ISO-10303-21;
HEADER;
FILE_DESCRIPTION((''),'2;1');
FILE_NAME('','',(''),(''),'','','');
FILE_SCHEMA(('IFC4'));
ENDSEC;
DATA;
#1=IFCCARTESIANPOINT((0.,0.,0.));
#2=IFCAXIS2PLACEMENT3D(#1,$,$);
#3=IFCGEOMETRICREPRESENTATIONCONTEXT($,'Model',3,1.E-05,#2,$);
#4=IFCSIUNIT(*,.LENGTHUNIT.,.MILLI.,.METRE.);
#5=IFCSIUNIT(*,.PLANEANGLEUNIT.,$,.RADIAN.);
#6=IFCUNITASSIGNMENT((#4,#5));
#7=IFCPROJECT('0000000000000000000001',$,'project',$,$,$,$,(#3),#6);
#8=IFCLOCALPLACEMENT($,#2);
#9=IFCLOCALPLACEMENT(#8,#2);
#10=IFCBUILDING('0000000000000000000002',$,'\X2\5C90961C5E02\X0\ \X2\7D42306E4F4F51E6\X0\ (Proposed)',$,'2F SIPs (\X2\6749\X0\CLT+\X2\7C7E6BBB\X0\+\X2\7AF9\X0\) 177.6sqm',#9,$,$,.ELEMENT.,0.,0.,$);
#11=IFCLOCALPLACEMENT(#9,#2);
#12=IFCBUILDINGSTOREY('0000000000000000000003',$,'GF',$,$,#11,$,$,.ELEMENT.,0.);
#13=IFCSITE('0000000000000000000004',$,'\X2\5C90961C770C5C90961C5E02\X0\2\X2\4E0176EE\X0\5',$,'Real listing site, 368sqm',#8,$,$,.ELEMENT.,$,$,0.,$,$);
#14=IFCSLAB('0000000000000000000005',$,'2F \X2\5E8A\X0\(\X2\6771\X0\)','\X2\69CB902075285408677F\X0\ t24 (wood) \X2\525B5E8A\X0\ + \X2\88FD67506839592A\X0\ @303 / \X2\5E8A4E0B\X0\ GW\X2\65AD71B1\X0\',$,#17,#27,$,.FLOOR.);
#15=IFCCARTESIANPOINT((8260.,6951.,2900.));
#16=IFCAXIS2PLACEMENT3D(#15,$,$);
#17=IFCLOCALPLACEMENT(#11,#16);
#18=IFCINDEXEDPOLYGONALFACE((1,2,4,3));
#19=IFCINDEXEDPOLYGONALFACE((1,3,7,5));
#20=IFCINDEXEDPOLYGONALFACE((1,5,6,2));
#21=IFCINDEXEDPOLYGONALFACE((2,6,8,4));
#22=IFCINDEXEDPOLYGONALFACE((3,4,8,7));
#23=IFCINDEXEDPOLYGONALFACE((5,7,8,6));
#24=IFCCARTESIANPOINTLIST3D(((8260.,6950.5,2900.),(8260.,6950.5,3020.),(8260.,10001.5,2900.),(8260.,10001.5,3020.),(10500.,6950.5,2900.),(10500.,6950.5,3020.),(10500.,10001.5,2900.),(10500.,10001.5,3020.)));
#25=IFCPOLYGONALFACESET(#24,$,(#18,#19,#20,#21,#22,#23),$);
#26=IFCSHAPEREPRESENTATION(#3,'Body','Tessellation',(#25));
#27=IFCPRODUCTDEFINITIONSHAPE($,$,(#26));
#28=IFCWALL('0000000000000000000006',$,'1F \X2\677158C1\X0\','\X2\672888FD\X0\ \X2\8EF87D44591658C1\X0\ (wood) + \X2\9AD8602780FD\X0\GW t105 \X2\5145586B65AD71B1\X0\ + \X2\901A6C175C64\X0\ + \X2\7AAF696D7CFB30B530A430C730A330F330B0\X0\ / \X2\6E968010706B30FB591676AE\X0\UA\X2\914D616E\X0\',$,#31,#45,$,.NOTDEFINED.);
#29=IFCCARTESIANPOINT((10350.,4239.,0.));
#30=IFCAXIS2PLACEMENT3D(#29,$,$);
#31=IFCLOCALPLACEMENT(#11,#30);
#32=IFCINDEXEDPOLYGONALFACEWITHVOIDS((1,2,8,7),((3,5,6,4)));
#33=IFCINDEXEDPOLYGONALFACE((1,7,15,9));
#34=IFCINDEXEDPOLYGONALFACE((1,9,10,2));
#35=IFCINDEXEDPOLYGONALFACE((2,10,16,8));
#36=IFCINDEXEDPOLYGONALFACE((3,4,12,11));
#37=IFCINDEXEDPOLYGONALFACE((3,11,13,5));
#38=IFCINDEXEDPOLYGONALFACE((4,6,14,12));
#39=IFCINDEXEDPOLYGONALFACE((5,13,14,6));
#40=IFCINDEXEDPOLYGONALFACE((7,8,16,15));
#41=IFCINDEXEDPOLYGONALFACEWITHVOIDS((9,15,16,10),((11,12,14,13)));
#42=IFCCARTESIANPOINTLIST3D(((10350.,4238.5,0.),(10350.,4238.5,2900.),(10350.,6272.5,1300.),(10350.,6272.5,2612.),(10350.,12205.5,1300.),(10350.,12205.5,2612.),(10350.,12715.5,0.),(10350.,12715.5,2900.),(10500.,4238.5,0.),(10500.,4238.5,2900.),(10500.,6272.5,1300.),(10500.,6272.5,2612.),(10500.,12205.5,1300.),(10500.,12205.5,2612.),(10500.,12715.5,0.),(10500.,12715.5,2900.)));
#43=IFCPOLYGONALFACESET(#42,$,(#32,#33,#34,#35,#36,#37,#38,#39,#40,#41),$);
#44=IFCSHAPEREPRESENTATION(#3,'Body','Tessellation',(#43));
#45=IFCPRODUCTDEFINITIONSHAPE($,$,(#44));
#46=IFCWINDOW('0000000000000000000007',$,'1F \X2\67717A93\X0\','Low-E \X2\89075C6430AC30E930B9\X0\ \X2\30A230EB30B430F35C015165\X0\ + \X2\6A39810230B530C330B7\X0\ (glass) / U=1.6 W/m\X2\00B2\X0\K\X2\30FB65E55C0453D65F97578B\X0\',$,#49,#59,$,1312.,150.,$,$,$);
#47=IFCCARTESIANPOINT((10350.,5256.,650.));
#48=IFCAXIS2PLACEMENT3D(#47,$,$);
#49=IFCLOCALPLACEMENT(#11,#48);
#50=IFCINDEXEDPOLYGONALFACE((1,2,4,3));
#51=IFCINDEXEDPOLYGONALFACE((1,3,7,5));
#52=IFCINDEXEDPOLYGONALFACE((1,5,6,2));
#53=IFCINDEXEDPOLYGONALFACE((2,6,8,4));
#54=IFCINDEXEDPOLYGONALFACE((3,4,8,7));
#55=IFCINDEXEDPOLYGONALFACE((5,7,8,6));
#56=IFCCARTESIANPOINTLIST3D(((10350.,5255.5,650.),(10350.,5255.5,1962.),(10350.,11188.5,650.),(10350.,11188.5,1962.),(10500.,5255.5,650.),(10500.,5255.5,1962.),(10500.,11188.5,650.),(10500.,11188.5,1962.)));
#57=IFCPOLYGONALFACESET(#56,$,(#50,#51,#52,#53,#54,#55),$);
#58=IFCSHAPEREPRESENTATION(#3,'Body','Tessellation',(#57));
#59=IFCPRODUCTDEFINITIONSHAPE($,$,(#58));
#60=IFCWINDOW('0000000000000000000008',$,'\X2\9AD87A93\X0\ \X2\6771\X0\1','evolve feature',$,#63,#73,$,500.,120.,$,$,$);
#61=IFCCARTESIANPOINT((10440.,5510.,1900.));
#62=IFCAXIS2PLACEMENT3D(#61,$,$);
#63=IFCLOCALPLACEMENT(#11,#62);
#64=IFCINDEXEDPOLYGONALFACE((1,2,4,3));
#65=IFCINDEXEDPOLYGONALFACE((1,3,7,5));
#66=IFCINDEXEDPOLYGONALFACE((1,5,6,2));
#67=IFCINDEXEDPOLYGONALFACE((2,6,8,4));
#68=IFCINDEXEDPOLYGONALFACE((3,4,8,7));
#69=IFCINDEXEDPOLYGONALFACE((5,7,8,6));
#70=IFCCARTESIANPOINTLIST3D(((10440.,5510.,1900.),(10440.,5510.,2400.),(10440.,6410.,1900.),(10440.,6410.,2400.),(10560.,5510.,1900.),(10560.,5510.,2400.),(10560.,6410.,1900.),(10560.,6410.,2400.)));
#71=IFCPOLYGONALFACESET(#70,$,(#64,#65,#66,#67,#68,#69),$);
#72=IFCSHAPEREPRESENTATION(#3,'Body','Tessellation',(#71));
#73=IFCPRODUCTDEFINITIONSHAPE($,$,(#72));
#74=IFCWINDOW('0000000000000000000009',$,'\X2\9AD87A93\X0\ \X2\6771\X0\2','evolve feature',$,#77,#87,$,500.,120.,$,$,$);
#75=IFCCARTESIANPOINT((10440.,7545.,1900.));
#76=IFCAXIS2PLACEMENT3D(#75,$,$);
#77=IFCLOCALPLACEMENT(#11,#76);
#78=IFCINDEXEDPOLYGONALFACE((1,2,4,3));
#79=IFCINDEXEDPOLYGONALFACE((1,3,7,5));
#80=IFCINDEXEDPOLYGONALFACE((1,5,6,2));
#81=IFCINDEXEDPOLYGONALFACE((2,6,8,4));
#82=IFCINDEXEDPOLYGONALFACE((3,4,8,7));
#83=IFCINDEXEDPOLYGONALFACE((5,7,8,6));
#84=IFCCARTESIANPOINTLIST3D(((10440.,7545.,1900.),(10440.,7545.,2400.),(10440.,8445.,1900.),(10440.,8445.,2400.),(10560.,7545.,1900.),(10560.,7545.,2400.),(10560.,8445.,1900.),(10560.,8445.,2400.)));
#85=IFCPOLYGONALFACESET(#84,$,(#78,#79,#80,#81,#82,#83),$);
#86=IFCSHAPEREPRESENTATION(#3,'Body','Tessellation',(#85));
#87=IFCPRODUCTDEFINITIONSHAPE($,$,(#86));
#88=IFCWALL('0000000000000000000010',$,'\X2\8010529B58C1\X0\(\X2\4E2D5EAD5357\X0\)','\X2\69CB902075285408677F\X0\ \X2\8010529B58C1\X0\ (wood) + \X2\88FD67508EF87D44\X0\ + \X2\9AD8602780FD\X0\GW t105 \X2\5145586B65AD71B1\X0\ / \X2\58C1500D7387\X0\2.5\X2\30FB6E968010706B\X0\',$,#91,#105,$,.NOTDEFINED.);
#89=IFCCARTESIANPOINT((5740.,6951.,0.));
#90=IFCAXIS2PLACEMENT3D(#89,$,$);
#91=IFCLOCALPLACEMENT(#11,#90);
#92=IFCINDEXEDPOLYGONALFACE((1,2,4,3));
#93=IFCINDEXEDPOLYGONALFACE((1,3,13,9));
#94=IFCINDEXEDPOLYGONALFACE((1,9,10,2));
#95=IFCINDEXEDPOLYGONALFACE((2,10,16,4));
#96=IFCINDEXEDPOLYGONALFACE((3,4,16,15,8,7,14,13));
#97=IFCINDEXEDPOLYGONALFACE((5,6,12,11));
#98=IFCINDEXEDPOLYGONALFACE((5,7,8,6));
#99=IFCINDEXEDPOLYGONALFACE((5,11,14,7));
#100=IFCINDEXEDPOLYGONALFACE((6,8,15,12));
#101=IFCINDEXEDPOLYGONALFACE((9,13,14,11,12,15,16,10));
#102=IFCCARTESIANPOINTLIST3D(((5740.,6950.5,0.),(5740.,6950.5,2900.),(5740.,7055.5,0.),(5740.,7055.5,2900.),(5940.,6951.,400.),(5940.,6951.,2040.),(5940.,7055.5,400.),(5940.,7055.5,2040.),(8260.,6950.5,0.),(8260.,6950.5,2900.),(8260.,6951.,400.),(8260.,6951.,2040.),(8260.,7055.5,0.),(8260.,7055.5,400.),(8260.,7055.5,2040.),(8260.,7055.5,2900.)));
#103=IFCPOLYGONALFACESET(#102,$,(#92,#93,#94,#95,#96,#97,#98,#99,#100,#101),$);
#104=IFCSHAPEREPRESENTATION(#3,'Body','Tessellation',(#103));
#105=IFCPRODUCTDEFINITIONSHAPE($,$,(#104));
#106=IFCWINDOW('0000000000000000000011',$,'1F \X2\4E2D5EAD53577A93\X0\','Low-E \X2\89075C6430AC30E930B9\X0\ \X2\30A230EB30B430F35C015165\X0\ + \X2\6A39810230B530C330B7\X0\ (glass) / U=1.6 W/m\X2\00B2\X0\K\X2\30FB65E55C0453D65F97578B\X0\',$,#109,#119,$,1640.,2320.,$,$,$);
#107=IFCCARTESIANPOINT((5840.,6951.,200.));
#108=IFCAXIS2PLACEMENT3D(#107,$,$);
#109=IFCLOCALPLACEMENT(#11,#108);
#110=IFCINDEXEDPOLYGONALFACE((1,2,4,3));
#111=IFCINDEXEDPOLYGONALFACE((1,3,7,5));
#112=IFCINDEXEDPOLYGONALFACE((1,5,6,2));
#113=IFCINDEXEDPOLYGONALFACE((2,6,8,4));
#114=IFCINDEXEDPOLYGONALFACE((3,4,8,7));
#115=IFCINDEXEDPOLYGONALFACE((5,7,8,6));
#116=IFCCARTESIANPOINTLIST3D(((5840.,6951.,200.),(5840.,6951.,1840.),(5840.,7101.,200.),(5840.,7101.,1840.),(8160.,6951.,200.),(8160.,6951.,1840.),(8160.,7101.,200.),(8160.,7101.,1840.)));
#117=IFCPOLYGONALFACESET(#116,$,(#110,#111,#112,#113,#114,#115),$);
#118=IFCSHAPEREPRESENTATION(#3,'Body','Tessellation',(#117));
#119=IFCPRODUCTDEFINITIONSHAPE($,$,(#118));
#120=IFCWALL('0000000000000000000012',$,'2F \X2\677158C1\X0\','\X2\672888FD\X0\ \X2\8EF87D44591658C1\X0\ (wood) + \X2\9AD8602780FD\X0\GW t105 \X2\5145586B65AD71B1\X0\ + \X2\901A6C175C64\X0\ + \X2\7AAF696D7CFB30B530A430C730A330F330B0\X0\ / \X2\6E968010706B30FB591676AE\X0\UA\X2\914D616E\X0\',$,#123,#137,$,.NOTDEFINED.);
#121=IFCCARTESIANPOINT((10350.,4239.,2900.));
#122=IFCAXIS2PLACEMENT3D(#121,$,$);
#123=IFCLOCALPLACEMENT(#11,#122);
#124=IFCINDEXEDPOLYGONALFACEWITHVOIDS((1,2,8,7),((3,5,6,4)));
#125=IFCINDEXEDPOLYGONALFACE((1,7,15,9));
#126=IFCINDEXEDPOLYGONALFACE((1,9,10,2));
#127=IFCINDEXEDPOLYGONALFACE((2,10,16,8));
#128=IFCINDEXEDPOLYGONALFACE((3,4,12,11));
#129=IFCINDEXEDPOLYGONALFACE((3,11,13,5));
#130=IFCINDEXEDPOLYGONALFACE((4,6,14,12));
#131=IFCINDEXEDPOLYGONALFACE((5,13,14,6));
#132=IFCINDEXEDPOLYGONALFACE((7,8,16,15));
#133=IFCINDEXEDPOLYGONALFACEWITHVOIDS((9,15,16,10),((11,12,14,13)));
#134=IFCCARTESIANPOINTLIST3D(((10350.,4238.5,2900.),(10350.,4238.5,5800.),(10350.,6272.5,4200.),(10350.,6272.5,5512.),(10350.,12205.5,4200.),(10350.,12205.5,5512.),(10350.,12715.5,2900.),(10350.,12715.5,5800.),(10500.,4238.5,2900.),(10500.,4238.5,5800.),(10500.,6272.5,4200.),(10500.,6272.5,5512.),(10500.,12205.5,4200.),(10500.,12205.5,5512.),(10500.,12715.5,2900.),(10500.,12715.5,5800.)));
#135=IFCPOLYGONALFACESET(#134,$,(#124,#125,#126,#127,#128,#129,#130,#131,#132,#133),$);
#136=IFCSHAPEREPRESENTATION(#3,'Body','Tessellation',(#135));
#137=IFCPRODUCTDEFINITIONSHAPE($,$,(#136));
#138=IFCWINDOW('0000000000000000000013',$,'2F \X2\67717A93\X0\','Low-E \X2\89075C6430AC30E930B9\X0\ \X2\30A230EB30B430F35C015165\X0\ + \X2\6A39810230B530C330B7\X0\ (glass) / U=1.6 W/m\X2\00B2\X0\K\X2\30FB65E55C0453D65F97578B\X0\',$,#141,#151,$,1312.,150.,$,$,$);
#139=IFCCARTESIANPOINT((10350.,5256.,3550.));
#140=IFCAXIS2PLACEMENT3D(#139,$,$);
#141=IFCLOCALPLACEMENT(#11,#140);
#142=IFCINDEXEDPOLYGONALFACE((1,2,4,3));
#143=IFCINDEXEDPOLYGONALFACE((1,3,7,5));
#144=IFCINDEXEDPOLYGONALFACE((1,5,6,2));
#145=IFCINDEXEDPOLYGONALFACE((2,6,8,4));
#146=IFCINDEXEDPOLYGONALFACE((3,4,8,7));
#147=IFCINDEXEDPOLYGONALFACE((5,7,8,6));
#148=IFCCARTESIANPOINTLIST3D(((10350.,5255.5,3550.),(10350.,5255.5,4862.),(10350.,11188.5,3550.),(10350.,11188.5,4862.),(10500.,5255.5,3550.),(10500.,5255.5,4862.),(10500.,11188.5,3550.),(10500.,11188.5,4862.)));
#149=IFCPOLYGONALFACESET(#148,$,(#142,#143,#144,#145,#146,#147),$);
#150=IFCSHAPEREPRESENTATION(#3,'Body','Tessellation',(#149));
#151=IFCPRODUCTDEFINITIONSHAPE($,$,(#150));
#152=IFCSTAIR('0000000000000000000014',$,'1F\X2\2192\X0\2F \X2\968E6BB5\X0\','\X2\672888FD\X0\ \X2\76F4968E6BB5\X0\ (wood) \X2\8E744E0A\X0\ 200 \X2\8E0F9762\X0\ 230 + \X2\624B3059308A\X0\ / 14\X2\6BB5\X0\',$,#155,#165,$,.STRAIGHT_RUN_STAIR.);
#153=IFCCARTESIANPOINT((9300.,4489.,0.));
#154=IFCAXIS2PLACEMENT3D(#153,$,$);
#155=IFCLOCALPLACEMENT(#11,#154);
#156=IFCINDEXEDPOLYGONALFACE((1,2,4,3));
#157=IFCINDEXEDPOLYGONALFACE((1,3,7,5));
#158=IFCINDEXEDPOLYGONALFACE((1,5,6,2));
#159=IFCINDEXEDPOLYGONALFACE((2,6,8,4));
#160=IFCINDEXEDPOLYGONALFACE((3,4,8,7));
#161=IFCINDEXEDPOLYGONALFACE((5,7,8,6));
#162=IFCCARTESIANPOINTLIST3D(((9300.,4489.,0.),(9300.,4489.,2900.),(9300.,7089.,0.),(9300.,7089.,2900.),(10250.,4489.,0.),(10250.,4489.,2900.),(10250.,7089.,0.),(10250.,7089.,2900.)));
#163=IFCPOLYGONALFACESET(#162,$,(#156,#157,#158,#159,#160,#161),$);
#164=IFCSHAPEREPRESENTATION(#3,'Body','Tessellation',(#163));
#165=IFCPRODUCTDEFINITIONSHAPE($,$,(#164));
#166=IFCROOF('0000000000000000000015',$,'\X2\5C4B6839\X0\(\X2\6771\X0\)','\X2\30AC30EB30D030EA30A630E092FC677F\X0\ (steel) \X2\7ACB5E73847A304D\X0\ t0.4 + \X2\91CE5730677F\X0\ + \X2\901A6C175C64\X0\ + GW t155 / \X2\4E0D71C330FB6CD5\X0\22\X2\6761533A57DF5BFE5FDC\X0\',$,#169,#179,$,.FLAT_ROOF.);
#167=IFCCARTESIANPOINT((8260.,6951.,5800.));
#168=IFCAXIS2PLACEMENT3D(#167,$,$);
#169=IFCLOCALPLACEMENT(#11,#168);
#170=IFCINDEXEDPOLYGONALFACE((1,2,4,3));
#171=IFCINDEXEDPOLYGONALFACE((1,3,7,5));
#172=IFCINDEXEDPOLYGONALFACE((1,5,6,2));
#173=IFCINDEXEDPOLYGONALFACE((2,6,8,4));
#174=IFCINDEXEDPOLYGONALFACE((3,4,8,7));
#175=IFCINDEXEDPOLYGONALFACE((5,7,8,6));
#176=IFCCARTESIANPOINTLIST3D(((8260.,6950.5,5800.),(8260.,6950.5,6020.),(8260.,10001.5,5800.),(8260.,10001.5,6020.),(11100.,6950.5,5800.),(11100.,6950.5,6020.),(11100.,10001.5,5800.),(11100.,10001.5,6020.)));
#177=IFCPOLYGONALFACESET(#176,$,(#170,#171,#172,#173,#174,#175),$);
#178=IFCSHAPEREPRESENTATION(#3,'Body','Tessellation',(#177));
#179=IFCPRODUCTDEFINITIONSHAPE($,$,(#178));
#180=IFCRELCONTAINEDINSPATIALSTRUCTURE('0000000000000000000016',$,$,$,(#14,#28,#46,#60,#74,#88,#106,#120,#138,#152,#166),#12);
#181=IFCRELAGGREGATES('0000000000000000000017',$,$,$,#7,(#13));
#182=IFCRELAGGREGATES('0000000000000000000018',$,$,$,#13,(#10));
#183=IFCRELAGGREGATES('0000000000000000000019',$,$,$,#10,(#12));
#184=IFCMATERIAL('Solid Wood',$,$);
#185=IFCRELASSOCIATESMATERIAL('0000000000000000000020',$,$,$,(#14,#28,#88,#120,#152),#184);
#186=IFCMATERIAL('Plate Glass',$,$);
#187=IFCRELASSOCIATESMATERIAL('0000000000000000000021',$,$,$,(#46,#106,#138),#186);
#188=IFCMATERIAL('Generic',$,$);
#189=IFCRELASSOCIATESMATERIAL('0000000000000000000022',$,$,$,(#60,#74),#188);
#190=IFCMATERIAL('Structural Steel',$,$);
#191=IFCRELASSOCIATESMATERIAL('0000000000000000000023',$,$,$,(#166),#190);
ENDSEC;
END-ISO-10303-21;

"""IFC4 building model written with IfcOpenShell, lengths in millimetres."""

from ifc_helpers import new_model, si_unit, frame, frame_2d, origin, place, context, project, spatial, rectangle, extrude, material, element, fill, save


model = new_model("IFC4")

# Units and contexts
model_context = context("Model", 3, precision=1e-05, world=origin())
ifc_project = project(units=[si_unit("LENGTHUNIT", "METRE", prefix="MILLI"), si_unit("PLANEANGLEUNIT", "RADIAN")], contexts=[model_context])

# Site, building, storey
site_placement = place(None, origin())
site = spatial("IfcSite", under=ifc_project, at=site_placement, Name="岐阜県岐阜市2丁目5", ObjectType="Real listing site, 368sqm", CompositionType="ELEMENT", RefElevation=0.0)
building_placement = place(site_placement, origin())
building = spatial("IfcBuilding", under=site, at=building_placement, Name="岐阜市 終の住処 (Proposed)", ObjectType="2F SIPs (杉CLT+籾殻+竹) 177.6sqm", CompositionType="ELEMENT", ElevationOfRefHeight=0.0, ElevationOfTerrain=0.0)
storey_placement = place(building_placement, origin())
storey = spatial("IfcBuildingStorey", under=building, at=storey_placement, Name="GF", CompositionType="ELEMENT", Elevation=0.0)

# Slab
ifc_material_1 = material(Name="Solid Wood")
slab_1_placement = place(storey_placement, frame((8260.0, 6951.0, 2900.0)))
element("IfcSlab", 1, at=slab_1_placement, inside=storey, material=ifc_material_1, Name="2F 床(東)", Description="構造用合板 t24 (wood) 剛床 + 製材根太 @303 / 床下 GW断熱", PredefinedType="FLOOR", context=model_context, shape_type="SweptSolid", body=[
    extrude(rectangle(XDim=2240.0, YDim=3051.0, at=frame_2d((1120.0, 1525.0))), frame((8260.0, 6951.0, 2900.0)), (0.0, 0.0, 1.0), 120.0),
])

# Wall, openings, windows
wall_1_placement = place(storey_placement, frame((10350.0, 4239.0, 0.0)))
wall_1 = element("IfcWall", 2, at=wall_1_placement, inside=storey, material=ifc_material_1, Name="1F 東壁", Description="木製 軸組外壁 (wood) + 高性能GW t105 充填断熱 + 通気層 + 窯業系サイディング / 準耐火・外皮UA配慮", PredefinedType="NOTDEFINED", context=model_context, shape_type="SweptSolid", body=[
    extrude(rectangle(XDim=150.0, YDim=8477.0, at=frame_2d((75.0, 4238.0))), frame((10350.0, 4239.0, 0.0)), (0.0, 0.0, 1.0), 2900.0),
])
opening_1_placement = place(storey_placement, frame((10350.0, 5256.0, 650.0)))
opening_1 = element("IfcOpeningElement", 3, at=opening_1_placement, cuts=wall_1, PredefinedType="NOTDEFINED", context=model_context, shape_type="SweptSolid", body=[
    extrude(rectangle(XDim=150.0, YDim=5933.0, at=frame_2d((75.0, 2966.0))), frame((10350.0, 5256.0, 650.0)), (0.0, 0.0, 1.0), 1312.0),
])
opening_2_placement = place(storey_placement, frame((10440.0, 5510.0, 1900.0)))
opening_2 = element("IfcOpeningElement", 4, at=opening_2_placement, cuts=wall_1, PredefinedType="NOTDEFINED", context=model_context, shape_type="SweptSolid", body=[
    extrude(rectangle(XDim=120.0, YDim=900.0, at=frame_2d((60.0, 450.0))), frame((10440.0, 5510.0, 1900.0)), (0.0, 0.0, 1.0), 500.0),
])
opening_3_placement = place(storey_placement, frame((10440.0, 7545.0, 1900.0)))
opening_3 = element("IfcOpeningElement", 5, at=opening_3_placement, cuts=wall_1, PredefinedType="NOTDEFINED", context=model_context, shape_type="SweptSolid", body=[
    extrude(rectangle(XDim=120.0, YDim=900.0, at=frame_2d((60.0, 450.0))), frame((10440.0, 7545.0, 1900.0)), (0.0, 0.0, 1.0), 500.0),
])
ifc_material_2 = material(Name="Plate Glass")
window_1_placement = place(storey_placement, frame((10350.0, 5256.0, 650.0)))
window_1 = element("IfcWindow", 6, at=window_1_placement, inside=storey, material=ifc_material_2, Name="1F 東窓", Description="Low-E 複層ガラス アルゴン封入 + 樹脂サッシ (glass) / U=1.6 W/m²K・日射取得型", OverallHeight=1312.0, OverallWidth=150.0, context=model_context, shape_type="SweptSolid", body=[
    extrude(rectangle(XDim=150.0, YDim=5933.0, at=frame_2d((75.0, 2966.0))), frame((10350.0, 5256.0, 650.0)), (0.0, 0.0, 1.0), 1312.0),
])
fill(opening_1, window_1)
ifc_material_3 = material(Name="Generic")
window_2_placement = place(storey_placement, frame((10440.0, 5510.0, 1900.0)))
window_2 = element("IfcWindow", 7, at=window_2_placement, inside=storey, material=ifc_material_3, Name="高窓 東1", Description="evolve feature", OverallHeight=500.0, OverallWidth=120.0, context=model_context, shape_type="SweptSolid", body=[
    extrude(rectangle(XDim=120.0, YDim=900.0, at=frame_2d((60.0, 450.0))), frame((10440.0, 5510.0, 1900.0)), (0.0, 0.0, 1.0), 500.0),
])
fill(opening_2, window_2)
window_3_placement = place(storey_placement, frame((10440.0, 7545.0, 1900.0)))
window_3 = element("IfcWindow", 8, at=window_3_placement, inside=storey, material=ifc_material_3, Name="高窓 東2", Description="evolve feature", OverallHeight=500.0, OverallWidth=120.0, context=model_context, shape_type="SweptSolid", body=[
    extrude(rectangle(XDim=120.0, YDim=900.0, at=frame_2d((60.0, 450.0))), frame((10440.0, 7545.0, 1900.0)), (0.0, 0.0, 1.0), 500.0),
])
fill(opening_3, window_3)

# Wall, opening, window
wall_2_placement = place(storey_placement, frame((5740.0, 6951.0, 0.0)))
wall_2 = element("IfcWall", 9, at=wall_2_placement, inside=storey, material=ifc_material_1, Name="耐力壁(中庭南)", Description="構造用合板 耐力壁 (wood) + 製材軸組 + 高性能GW t105 充填断熱 / 壁倍率2.5・準耐火", PredefinedType="NOTDEFINED", context=model_context, shape_type="SweptSolid", body=[
    extrude(rectangle(XDim=2520.0, YDim=105.0, at=frame_2d((1260.0, 52.0))), frame((5740.0, 6951.0, 0.0)), (0.0, 0.0, 1.0), 2900.0),
])
opening_4_placement = place(storey_placement, frame((5840.0, 6951.0, 200.0)))
opening_4 = element("IfcOpeningElement", 10, at=opening_4_placement, cuts=wall_2, PredefinedType="NOTDEFINED", context=model_context, shape_type="SweptSolid", body=[
    extrude(rectangle(XDim=2320.0, YDim=150.0, at=frame_2d((1160.0, 75.0))), frame((5840.0, 6951.0, 200.0)), (0.0, 0.0, 1.0), 1640.0),
])
window_4_placement = place(storey_placement, frame((5840.0, 6951.0, 200.0)))
window_4 = element("IfcWindow", 11, at=window_4_placement, inside=storey, material=ifc_material_2, Name="1F 中庭南窓", Description="Low-E 複層ガラス アルゴン封入 + 樹脂サッシ (glass) / U=1.6 W/m²K・日射取得型", OverallHeight=1640.0, OverallWidth=2320.0, context=model_context, shape_type="SweptSolid", body=[
    extrude(rectangle(XDim=2320.0, YDim=150.0, at=frame_2d((1160.0, 75.0))), frame((5840.0, 6951.0, 200.0)), (0.0, 0.0, 1.0), 1640.0),
])
fill(opening_4, window_4)

# Wall, opening, window
wall_3_placement = place(storey_placement, frame((10350.0, 4239.0, 2900.0)))
wall_3 = element("IfcWall", 12, at=wall_3_placement, inside=storey, material=ifc_material_1, Name="2F 東壁", Description="木製 軸組外壁 (wood) + 高性能GW t105 充填断熱 + 通気層 + 窯業系サイディング / 準耐火・外皮UA配慮", PredefinedType="NOTDEFINED", context=model_context, shape_type="SweptSolid", body=[
    extrude(rectangle(XDim=150.0, YDim=8477.0, at=frame_2d((75.0, 4238.0))), frame((10350.0, 4239.0, 2900.0)), (0.0, 0.0, 1.0), 2900.0),
])
opening_5_placement = place(storey_placement, frame((10350.0, 5256.0, 3550.0)))
opening_5 = element("IfcOpeningElement", 13, at=opening_5_placement, cuts=wall_3, PredefinedType="NOTDEFINED", context=model_context, shape_type="SweptSolid", body=[
    extrude(rectangle(XDim=150.0, YDim=5933.0, at=frame_2d((75.0, 2966.0))), frame((10350.0, 5256.0, 3550.0)), (0.0, 0.0, 1.0), 1312.0),
])
window_5_placement = place(storey_placement, frame((10350.0, 5256.0, 3550.0)))
window_5 = element("IfcWindow", 14, at=window_5_placement, inside=storey, material=ifc_material_2, Name="2F 東窓", Description="Low-E 複層ガラス アルゴン封入 + 樹脂サッシ (glass) / U=1.6 W/m²K・日射取得型", OverallHeight=1312.0, OverallWidth=150.0, context=model_context, shape_type="SweptSolid", body=[
    extrude(rectangle(XDim=150.0, YDim=5933.0, at=frame_2d((75.0, 2966.0))), frame((10350.0, 5256.0, 3550.0)), (0.0, 0.0, 1.0), 1312.0),
])
fill(opening_5, window_5)

# Stair
stair_placement = place(storey_placement, frame((9300.0, 4489.0, 0.0)))
element("IfcStair", 15, at=stair_placement, inside=storey, material=ifc_material_1, Name="1F→2F 階段", Description="木製 直階段 (wood) 蹴上 200 踏面 230 + 手すり / 14段", PredefinedType="STRAIGHT_RUN_STAIR", context=model_context, shape_type="SweptSolid", body=[
    extrude(rectangle(XDim=950.0, YDim=2600.0, at=frame_2d((475.0, 1300.0))), frame((9300.0, 4489.0, 0.0)), (0.0, 0.0, 1.0), 2900.0),
])

# Roof
ifc_material_4 = material(Name="Structural Steel")
roof_placement = place(storey_placement, frame((8260.0, 6951.0, 5800.0)))
element("IfcRoof", 16, at=roof_placement, inside=storey, material=ifc_material_4, Name="屋根(東)", Description="ガルバリウム鋼板 (steel) 立平葺き t0.4 + 野地板 + 通気層 + GW t155 / 不燃・法22条区域対応", PredefinedType="FLAT_ROOF", context=model_context, shape_type="SweptSolid", body=[
    extrude(rectangle(XDim=2840.0, YDim=3051.0, at=frame_2d((1420.0, 1525.0))), frame((8260.0, 6951.0, 5800.0)), (0.0, 0.0, 1.0), 220.0),
])

save(model, "model.ifc")
